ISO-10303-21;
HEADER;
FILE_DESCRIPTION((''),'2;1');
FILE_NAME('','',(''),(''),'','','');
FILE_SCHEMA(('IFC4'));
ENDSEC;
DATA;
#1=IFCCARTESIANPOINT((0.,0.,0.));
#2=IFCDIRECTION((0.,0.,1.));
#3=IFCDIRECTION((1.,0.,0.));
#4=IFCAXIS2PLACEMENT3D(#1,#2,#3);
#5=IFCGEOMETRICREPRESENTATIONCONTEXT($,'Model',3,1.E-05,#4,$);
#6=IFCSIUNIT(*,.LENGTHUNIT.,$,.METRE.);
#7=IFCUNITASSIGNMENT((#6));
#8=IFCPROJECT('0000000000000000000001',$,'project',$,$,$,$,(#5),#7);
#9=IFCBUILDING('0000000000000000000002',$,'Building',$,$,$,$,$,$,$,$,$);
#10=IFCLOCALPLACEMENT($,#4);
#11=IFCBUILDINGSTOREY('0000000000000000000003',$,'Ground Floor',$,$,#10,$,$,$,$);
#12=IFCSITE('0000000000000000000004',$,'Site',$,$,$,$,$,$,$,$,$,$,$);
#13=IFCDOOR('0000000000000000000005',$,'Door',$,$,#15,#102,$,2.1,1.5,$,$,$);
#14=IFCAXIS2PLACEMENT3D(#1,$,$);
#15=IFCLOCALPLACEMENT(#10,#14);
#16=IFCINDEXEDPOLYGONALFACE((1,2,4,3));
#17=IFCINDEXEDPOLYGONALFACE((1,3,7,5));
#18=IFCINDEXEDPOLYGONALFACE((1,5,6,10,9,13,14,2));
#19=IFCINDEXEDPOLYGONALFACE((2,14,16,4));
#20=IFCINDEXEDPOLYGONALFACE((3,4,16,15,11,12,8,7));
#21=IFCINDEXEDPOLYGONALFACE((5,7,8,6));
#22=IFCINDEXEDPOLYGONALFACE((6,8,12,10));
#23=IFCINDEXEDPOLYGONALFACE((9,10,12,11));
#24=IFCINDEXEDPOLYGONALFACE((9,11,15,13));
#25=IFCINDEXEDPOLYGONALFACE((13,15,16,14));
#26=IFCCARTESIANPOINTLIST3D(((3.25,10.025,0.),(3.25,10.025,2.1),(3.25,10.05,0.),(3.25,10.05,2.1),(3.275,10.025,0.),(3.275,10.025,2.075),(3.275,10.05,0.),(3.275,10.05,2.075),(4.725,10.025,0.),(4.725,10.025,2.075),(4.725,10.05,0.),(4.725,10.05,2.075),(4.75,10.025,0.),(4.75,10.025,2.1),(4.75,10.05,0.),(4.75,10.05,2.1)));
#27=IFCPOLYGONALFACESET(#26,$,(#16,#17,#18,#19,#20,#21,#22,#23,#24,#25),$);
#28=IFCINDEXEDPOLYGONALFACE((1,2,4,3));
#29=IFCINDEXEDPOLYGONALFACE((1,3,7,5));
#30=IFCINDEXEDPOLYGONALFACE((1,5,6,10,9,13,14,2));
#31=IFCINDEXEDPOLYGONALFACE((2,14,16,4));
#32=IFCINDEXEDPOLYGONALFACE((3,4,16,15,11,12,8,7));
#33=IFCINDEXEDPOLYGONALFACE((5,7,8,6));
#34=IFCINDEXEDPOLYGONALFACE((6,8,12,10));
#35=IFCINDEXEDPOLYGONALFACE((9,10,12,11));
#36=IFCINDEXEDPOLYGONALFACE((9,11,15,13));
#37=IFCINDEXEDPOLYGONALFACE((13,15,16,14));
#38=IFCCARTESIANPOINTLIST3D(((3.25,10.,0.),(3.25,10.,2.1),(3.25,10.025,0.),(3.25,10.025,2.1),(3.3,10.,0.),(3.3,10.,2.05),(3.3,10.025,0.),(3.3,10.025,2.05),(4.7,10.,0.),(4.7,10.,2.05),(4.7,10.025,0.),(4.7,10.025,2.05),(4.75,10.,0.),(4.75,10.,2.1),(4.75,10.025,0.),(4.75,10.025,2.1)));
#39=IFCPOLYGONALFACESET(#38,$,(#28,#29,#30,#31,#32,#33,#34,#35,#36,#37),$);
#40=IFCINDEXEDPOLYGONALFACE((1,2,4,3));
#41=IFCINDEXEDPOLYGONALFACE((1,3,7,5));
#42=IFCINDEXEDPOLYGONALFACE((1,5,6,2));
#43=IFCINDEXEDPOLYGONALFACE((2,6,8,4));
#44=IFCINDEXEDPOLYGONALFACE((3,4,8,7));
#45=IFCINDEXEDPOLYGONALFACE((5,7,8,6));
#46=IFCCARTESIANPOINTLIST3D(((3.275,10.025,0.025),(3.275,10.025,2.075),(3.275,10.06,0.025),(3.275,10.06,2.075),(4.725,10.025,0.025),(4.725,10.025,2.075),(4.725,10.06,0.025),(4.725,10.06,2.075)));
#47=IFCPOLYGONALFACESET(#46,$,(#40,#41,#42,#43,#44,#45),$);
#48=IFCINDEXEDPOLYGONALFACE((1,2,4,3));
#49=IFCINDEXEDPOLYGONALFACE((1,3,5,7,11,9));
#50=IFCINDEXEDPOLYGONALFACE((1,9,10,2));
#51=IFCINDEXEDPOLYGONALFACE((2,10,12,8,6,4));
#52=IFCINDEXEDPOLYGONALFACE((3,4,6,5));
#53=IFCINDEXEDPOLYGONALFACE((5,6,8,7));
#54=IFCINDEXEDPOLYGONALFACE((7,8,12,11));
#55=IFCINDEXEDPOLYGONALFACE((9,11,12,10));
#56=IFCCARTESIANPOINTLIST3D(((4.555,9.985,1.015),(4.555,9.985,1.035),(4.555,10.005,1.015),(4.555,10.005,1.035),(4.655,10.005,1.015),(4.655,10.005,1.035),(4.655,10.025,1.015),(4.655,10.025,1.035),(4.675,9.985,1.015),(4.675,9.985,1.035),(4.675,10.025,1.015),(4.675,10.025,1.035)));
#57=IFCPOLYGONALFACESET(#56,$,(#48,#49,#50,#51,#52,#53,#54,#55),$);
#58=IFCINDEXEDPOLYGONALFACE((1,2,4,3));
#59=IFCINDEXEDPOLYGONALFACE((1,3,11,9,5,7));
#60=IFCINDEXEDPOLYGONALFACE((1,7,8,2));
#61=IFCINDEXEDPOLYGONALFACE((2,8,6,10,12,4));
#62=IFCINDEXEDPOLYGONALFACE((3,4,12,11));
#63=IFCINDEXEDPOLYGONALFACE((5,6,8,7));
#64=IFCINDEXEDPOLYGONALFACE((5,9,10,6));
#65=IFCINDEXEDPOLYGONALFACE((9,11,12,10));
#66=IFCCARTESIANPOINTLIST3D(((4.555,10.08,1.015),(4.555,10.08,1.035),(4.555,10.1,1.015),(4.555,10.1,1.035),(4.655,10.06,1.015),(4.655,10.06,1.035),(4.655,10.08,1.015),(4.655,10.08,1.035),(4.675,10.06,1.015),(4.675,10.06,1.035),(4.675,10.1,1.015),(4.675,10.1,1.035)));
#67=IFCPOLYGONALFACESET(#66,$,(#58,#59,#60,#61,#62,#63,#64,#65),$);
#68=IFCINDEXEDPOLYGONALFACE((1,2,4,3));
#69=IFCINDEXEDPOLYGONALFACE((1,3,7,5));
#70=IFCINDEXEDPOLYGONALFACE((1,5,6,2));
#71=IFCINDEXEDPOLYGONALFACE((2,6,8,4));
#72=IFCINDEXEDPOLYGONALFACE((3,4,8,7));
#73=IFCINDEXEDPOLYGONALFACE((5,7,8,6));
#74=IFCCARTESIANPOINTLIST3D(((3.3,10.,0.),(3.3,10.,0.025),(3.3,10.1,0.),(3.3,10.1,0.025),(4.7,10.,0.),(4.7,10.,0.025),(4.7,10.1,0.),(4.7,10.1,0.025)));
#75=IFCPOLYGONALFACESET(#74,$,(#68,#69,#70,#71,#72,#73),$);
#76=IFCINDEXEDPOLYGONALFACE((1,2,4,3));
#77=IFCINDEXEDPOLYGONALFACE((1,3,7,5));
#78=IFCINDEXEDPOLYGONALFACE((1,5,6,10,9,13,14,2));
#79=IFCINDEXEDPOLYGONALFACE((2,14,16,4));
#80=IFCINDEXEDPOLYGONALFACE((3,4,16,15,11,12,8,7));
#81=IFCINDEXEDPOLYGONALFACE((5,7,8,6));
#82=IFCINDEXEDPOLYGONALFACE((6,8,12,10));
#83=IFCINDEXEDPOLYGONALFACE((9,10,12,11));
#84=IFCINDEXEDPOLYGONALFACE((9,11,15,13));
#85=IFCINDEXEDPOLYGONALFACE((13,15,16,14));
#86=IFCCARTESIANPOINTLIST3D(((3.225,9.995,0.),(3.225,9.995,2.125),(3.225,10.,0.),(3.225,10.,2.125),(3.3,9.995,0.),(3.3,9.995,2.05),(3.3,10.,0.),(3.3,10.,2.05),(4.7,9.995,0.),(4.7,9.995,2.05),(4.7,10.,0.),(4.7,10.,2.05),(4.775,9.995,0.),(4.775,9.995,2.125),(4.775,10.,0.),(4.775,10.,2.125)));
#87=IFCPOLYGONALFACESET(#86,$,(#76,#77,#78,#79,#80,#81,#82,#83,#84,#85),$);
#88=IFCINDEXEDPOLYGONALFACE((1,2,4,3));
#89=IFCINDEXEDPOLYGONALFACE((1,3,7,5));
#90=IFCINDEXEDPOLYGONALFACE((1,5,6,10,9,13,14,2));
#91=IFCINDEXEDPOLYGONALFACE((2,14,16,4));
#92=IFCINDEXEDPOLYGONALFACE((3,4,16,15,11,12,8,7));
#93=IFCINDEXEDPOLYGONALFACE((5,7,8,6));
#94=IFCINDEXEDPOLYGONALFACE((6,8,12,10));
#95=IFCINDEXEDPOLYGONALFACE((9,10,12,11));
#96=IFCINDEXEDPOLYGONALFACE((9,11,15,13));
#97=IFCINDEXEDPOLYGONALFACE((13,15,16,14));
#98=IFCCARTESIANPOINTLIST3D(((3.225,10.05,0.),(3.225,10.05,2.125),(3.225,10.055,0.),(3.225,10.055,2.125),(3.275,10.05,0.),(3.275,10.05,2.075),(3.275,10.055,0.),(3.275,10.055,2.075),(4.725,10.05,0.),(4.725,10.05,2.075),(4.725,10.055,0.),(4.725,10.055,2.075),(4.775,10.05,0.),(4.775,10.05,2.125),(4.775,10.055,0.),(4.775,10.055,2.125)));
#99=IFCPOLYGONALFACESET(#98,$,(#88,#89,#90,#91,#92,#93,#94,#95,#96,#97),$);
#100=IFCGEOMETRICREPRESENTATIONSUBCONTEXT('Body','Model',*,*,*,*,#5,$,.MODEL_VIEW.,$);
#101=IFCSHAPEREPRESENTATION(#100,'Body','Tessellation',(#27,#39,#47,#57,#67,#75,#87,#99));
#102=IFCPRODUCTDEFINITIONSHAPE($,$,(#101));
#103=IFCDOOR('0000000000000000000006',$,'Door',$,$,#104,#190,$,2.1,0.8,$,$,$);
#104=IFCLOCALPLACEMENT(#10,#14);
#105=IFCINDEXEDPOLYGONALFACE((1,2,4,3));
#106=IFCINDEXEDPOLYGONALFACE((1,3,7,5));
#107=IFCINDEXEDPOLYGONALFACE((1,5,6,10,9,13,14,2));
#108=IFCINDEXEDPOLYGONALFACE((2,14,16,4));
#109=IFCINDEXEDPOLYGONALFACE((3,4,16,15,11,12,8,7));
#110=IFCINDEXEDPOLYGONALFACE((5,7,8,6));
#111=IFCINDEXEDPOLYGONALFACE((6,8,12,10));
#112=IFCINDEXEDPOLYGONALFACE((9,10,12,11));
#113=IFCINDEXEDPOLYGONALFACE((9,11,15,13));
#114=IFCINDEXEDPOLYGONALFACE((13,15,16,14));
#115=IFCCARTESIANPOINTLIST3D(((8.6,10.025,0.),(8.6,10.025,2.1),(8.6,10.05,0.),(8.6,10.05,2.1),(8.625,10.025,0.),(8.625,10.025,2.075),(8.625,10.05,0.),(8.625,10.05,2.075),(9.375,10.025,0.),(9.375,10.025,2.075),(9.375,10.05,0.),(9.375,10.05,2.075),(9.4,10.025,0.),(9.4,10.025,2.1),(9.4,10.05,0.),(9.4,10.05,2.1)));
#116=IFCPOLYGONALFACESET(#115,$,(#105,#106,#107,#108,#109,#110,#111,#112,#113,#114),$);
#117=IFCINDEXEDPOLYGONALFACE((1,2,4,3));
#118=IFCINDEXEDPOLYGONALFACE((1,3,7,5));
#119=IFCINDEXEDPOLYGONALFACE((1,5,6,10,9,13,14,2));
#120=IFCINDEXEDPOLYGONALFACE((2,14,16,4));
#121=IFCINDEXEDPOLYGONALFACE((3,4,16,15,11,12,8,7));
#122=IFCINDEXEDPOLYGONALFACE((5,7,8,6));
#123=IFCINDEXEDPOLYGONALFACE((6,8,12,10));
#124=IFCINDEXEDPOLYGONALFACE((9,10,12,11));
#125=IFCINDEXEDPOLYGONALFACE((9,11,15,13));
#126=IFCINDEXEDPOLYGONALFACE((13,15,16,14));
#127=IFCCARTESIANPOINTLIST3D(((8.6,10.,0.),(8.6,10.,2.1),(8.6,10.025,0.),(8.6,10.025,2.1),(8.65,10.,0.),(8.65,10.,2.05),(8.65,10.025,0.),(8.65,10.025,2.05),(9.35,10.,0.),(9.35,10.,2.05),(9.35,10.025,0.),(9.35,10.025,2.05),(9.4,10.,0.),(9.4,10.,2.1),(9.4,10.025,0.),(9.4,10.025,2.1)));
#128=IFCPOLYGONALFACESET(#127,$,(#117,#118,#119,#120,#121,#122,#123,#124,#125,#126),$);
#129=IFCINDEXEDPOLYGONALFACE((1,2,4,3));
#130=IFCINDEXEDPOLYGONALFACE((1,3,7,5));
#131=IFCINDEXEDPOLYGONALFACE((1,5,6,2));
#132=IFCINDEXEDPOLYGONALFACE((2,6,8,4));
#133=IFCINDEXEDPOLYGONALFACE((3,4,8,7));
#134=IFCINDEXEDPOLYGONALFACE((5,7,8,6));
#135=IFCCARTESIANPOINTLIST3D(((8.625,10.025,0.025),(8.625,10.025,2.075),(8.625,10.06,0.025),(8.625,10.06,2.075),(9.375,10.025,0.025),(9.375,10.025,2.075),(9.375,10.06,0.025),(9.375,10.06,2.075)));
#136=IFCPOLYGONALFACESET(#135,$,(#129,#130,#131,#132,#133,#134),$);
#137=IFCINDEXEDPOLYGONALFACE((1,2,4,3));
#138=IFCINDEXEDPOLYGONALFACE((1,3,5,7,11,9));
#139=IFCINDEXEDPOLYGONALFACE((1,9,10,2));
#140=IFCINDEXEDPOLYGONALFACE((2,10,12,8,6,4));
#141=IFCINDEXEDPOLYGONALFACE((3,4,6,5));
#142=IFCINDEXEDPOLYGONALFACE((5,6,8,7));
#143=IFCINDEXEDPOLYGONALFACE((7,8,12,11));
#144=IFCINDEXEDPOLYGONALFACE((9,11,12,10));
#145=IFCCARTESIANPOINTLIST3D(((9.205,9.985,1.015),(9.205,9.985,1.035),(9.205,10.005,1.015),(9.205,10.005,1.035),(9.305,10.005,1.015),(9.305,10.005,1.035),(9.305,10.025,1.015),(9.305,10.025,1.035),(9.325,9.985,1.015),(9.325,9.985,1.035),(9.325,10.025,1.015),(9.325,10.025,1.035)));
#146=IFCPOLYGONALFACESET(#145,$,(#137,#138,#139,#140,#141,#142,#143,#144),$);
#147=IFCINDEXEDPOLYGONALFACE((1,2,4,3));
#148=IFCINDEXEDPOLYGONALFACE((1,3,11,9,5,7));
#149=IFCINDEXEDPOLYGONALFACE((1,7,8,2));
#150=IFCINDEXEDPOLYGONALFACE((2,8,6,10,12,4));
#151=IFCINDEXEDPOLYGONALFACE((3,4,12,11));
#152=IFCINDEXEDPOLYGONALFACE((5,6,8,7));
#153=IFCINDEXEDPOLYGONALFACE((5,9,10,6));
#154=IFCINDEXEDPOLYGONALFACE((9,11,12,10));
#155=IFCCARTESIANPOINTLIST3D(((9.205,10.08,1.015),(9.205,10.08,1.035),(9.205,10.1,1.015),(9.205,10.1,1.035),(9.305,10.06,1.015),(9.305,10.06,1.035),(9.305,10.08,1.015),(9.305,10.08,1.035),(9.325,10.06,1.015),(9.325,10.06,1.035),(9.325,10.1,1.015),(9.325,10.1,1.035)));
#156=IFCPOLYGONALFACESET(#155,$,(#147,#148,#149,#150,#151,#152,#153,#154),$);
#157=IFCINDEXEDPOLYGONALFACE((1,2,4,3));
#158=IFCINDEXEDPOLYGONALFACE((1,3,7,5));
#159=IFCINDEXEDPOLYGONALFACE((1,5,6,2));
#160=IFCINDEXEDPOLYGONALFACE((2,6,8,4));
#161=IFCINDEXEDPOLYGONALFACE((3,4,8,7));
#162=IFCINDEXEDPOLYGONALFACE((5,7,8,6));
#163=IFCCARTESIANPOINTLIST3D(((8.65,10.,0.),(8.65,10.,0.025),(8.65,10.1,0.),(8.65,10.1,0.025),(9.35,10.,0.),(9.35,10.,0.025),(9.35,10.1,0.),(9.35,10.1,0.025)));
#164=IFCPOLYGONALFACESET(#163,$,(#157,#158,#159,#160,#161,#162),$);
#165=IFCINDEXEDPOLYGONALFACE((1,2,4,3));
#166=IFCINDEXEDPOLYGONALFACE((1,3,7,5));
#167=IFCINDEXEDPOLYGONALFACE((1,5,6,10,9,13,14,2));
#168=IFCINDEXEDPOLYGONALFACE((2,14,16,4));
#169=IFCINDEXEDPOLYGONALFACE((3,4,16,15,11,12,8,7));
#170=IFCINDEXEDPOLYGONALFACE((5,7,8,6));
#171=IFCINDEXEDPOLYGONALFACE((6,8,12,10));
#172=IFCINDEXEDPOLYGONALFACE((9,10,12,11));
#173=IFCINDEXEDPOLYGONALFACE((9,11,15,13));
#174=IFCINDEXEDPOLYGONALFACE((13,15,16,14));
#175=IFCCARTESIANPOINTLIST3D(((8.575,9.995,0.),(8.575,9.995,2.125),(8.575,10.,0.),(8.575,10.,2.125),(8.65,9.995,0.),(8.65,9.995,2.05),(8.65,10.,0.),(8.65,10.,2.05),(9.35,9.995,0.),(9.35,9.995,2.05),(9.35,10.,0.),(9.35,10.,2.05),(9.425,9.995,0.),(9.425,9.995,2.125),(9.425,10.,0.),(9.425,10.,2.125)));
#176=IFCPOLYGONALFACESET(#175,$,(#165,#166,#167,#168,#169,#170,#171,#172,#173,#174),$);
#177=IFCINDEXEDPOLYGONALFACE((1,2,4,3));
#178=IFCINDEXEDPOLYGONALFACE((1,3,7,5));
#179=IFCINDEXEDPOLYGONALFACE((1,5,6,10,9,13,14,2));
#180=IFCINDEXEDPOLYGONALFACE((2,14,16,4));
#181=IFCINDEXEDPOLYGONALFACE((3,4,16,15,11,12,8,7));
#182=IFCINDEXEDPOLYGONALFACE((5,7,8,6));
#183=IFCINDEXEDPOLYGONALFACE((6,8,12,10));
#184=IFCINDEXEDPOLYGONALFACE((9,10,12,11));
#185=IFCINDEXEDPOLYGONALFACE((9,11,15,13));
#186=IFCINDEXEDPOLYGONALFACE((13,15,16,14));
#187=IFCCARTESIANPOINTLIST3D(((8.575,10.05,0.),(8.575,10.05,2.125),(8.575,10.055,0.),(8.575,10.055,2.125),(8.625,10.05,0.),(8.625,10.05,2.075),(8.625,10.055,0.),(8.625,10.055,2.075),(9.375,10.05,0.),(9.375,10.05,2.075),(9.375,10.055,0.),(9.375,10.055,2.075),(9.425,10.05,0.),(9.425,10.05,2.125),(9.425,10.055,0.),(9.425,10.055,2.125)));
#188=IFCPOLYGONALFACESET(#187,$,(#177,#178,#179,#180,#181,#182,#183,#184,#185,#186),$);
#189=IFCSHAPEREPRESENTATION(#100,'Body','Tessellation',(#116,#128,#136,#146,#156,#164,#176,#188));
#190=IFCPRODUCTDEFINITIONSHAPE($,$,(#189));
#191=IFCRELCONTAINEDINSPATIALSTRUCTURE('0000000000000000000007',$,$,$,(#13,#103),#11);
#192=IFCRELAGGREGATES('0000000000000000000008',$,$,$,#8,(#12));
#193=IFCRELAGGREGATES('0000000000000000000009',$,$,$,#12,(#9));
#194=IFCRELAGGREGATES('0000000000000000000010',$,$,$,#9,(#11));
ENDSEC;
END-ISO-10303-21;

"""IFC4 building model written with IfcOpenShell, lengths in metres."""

from ifc_helpers import new_model, si_unit, frame, origin_with_axes, place, context, subcontext, project, spatial, line, indexed_curve, outline, extrude, element, save


model = new_model("IFC4")

# Units and contexts
model_context = context("Model", 3, precision=1e-05, world=origin_with_axes())
body_context = subcontext(model_context, "Body", "Model", "MODEL_VIEW")
ifc_project = project(units=[si_unit("LENGTHUNIT", "METRE")], contexts=[model_context])

# Site, building, storey
site = spatial("IfcSite", under=ifc_project, Name="Site")
building = spatial("IfcBuilding", under=site, Name="Building")
storey_placement = place(None, origin_with_axes())
storey = spatial("IfcBuildingStorey", under=building, at=storey_placement, Name="Ground Floor")

# Doors
door_1_placement = place(storey_placement, frame((3.25, 10.0, 0.0), z_axis=(0.0, 0.0, 1.0), x_axis=(1.0, 0.0, 0.0)))
element("IfcDoor", 1, at=door_1_placement, inside=storey, Name="Door", OverallHeight=2.1, OverallWidth=1.5, context=body_context, shape_type="SweptSolid", body=[
    extrude(outline(indexed_curve([(0.0, 0.0), (0.0, 2.1), (1.5, 2.1), (1.5, 0.0), (1.475, 0.0), (1.475, 2.075), (0.025, 2.075), (0.025, 0.0)], segments=[line(1, 2, 3, 4, 5, 6, 7, 8, 1)])), frame((0.0, 0.025, 0.0), z_axis=(0.0, -1.0, 0.0), x_axis=(1.0, 0.0, 0.0)), (0.0, 0.0, -1.0), 0.025),
    extrude(outline(indexed_curve([(0.0, 0.0), (0.0, 2.1), (1.5, 2.1), (1.5, 0.0), (1.45, 0.0), (1.45, 2.05), (0.05, 2.05), (0.05, 0.0)], segments=[line(1, 2, 3, 4, 5, 6, 7, 8, 1)])), frame((0.0, 0.0, 0.0), z_axis=(0.0, -1.0, 0.0), x_axis=(1.0, 0.0, 0.0)), (0.0, 0.0, -1.0), 0.025),
    extrude(outline(indexed_curve([(0.0, 0.0), (1.45, 0.0), (1.45, 0.035), (0.0, 0.035)], segments=[line(1, 2, 3, 4, 1)])), frame((0.025, 0.025, 0.025), z_axis=(0.0, 0.0, 1.0), x_axis=(1.0, 0.0, 0.0)), (0.0, 0.0, 1.0), 2.05),
    extrude(outline(indexed_curve([(0.0, 0.0), (0.0, -0.04), (-0.12, -0.04), (-0.12, -0.02), (-0.02, -0.02), (-0.02, 0.0)], segments=[line(1, 2, 3, 4, 5, 6, 1)])), frame((1.425, 0.025, 1.015), z_axis=(0.0, 0.0, 1.0), x_axis=(1.0, 0.0, 0.0)), (0.0, 0.0, 1.0), 0.02),
    extrude(outline(indexed_curve([(0.0, 0.0), (0.0, 0.04), (-0.12, 0.04), (-0.12, 0.02), (-0.02, 0.02), (-0.02, 0.0)], segments=[line(1, 2, 3, 4, 5, 6, 1)])), frame((1.425, 0.06, 1.015), z_axis=(0.0, 0.0, 1.0), x_axis=(1.0, 0.0, 0.0)), (0.0, 0.0, 1.0), 0.02),
    extrude(outline(indexed_curve([(0.0, 0.0), (1.4, 0.0), (1.4, 0.1), (0.0, 0.1)], segments=[line(1, 2, 3, 4, 1)])), frame((0.05, 0.0, 0.0), z_axis=(0.0, 0.0, 1.0), x_axis=(1.0, 0.0, 0.0)), (0.0, 0.0, 1.0), 0.025),
    extrude(outline(indexed_curve([(0.0, 0.0), (0.0, 2.125), (1.55, 2.125), (1.55, 0.0), (1.475, 0.0), (1.475, 2.05), (0.075, 2.05), (0.075, 0.0)], segments=[line(1, 2, 3, 4, 5, 6, 7, 8, 1)])), frame((-0.025, -0.005, 0.0), z_axis=(0.0, -1.0, 0.0), x_axis=(1.0, 0.0, 0.0)), (0.0, 0.0, -1.0), 0.005),
    extrude(outline(indexed_curve([(0.0, 0.0), (0.0, 2.125), (1.55, 2.125), (1.55, 0.0), (1.5, 0.0), (1.5, 2.075), (0.05, 2.075), (0.05, 0.0)], segments=[line(1, 2, 3, 4, 5, 6, 7, 8, 1)])), frame((-0.025, 0.05, 0.0), z_axis=(0.0, -1.0, 0.0), x_axis=(1.0, 0.0, 0.0)), (0.0, 0.0, -1.0), 0.005),
])
door_2_placement = place(storey_placement, frame((8.6, 10.0, 0.0), z_axis=(0.0, 0.0, 1.0), x_axis=(1.0, 0.0, 0.0)))
element("IfcDoor", 2, at=door_2_placement, inside=storey, Name="Door", OverallHeight=2.1, OverallWidth=0.8, context=body_context, shape_type="SweptSolid", body=[
    extrude(outline(indexed_curve([(0.0, 0.0), (0.0, 2.1), (0.8, 2.1), (0.8, 0.0), (0.775, 0.0), (0.775, 2.075), (0.025, 2.075), (0.025, 0.0)], segments=[line(1, 2, 3, 4, 5, 6, 7, 8, 1)])), frame((0.0, 0.025, 0.0), z_axis=(0.0, -1.0, 0.0), x_axis=(1.0, 0.0, 0.0)), (0.0, 0.0, -1.0), 0.025),
    extrude(outline(indexed_curve([(0.0, 0.0), (0.0, 2.1), (0.8, 2.1), (0.8, 0.0), (0.75, 0.0), (0.75, 2.05), (0.05, 2.05), (0.05, 0.0)], segments=[line(1, 2, 3, 4, 5, 6, 7, 8, 1)])), frame((0.0, 0.0, 0.0), z_axis=(0.0, -1.0, 0.0), x_axis=(1.0, 0.0, 0.0)), (0.0, 0.0, -1.0), 0.025),
    extrude(outline(indexed_curve([(0.0, 0.0), (0.75, 0.0), (0.75, 0.035), (0.0, 0.035)], segments=[line(1, 2, 3, 4, 1)])), frame((0.025, 0.025, 0.025), z_axis=(0.0, 0.0, 1.0), x_axis=(1.0, 0.0, 0.0)), (0.0, 0.0, 1.0), 2.05),
    extrude(outline(indexed_curve([(0.0, 0.0), (0.0, -0.04), (-0.12, -0.04), (-0.12, -0.02), (-0.02, -0.02), (-0.02, 0.0)], segments=[line(1, 2, 3, 4, 5, 6, 1)])), frame((0.725, 0.025, 1.015), z_axis=(0.0, 0.0, 1.0), x_axis=(1.0, 0.0, 0.0)), (0.0, 0.0, 1.0), 0.02),
    extrude(outline(indexed_curve([(0.0, 0.0), (0.0, 0.04), (-0.12, 0.04), (-0.12, 0.02), (-0.02, 0.02), (-0.02, 0.0)], segments=[line(1, 2, 3, 4, 5, 6, 1)])), frame((0.725, 0.06, 1.015), z_axis=(0.0, 0.0, 1.0), x_axis=(1.0, 0.0, 0.0)), (0.0, 0.0, 1.0), 0.02),
    extrude(outline(indexed_curve([(0.0, 0.0), (0.7, 0.0), (0.7, 0.1), (0.0, 0.1)], segments=[line(1, 2, 3, 4, 1)])), frame((0.05, 0.0, 0.0), z_axis=(0.0, 0.0, 1.0), x_axis=(1.0, 0.0, 0.0)), (0.0, 0.0, 1.0), 0.025),
    extrude(outline(indexed_curve([(0.0, 0.0), (0.0, 2.125), (0.85, 2.125), (0.85, 0.0), (0.775, 0.0), (0.775, 2.05), (0.075, 2.05), (0.075, 0.0)], segments=[line(1, 2, 3, 4, 5, 6, 7, 8, 1)])), frame((-0.025, -0.005, 0.0), z_axis=(0.0, -1.0, 0.0), x_axis=(1.0, 0.0, 0.0)), (0.0, 0.0, -1.0), 0.005),
    extrude(outline(indexed_curve([(0.0, 0.0), (0.0, 2.125), (0.85, 2.125), (0.85, 0.0), (0.8, 0.0), (0.8, 2.075), (0.05, 2.075), (0.05, 0.0)], segments=[line(1, 2, 3, 4, 5, 6, 7, 8, 1)])), frame((-0.025, 0.05, 0.0), z_axis=(0.0, -1.0, 0.0), x_axis=(1.0, 0.0, 0.0)), (0.0, 0.0, -1.0), 0.005),
])

save(model, "model.ifc")
